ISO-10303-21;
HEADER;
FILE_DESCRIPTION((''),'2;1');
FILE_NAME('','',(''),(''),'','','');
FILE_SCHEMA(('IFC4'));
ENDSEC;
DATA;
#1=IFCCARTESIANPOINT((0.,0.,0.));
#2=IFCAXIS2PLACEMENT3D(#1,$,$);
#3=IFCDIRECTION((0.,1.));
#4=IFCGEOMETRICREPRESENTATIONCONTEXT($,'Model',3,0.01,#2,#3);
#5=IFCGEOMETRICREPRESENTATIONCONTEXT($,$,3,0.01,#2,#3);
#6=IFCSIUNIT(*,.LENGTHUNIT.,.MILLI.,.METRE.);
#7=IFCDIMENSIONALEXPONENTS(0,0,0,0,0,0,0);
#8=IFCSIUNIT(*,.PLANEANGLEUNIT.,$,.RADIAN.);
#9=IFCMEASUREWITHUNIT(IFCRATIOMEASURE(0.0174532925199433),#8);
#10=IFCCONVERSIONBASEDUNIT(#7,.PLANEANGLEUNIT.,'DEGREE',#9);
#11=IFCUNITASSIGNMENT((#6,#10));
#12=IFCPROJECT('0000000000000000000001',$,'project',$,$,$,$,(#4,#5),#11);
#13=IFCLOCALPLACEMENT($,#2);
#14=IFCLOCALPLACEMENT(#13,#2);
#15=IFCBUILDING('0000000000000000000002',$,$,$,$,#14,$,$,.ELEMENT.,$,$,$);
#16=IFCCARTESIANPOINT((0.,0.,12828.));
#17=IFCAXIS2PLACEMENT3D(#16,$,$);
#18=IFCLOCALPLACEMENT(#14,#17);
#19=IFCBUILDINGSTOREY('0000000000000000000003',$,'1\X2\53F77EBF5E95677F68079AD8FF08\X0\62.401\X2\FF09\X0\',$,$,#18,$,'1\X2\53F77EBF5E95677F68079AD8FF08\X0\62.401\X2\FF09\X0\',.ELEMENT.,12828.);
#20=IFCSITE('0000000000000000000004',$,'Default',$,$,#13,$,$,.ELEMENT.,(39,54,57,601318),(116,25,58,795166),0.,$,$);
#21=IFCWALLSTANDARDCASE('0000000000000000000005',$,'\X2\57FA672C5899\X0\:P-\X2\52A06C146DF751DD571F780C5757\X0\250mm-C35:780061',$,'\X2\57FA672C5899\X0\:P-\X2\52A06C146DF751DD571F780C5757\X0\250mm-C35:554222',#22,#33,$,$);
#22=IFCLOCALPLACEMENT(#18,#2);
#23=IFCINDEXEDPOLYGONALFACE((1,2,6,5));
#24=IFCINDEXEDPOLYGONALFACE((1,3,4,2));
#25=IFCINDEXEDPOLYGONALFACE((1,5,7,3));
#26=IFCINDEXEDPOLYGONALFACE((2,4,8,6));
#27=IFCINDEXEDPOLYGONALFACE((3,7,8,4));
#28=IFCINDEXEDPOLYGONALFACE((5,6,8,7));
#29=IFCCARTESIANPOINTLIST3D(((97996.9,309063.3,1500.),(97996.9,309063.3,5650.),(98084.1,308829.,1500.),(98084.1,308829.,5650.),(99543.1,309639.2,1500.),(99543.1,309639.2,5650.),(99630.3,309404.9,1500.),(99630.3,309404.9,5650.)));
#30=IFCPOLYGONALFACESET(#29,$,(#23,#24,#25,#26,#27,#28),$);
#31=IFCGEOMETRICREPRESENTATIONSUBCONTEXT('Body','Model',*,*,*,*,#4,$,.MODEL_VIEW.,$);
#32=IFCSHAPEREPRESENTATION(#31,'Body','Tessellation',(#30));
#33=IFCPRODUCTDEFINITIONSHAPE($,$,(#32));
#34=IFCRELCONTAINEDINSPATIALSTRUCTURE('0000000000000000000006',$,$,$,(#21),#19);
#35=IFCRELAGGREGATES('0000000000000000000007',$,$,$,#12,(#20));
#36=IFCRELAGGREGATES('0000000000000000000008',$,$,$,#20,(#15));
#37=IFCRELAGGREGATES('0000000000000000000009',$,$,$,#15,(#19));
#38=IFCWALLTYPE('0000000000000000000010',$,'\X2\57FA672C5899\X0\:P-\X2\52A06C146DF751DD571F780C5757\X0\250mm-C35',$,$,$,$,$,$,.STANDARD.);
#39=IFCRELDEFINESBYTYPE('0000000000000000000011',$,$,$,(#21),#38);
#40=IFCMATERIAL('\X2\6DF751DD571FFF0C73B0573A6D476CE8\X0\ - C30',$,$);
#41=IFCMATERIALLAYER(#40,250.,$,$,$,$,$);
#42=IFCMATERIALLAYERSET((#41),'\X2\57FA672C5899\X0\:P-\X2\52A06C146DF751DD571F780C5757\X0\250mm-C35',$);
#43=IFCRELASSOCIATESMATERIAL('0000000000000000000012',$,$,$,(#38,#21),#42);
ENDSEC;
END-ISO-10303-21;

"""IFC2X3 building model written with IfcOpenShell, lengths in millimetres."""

from ifc_helpers import new_model, entity, si_unit, converted_unit, direction, frame, frame_2d, origin, place, context, subcontext, project, spatial, polyline, rectangle, extrude, clip, bounded_halfspace, material, layer, layer_set, layer_usage, type_object, element, save


model = new_model("IFC2X3")

# Units and contexts
model_context = context("Model", 3, precision=0.01, world=origin(), true_north=direction((0.0, 1.0)))
context_of_model = context(None, 3, precision=0.01, world=origin(), true_north=direction((0.0, 1.0)))
body_context = subcontext(model_context, "Body", "Model", "MODEL_VIEW")
ifc_project = project(units=[si_unit("LENGTHUNIT", "METRE", prefix="MILLI"), converted_unit("PLANEANGLEUNIT", "DEGREE", entity("IfcRatioMeasure", 0.0174532925199433), si_unit("PLANEANGLEUNIT", "RADIAN"), dimensions=[0, 0, 0, 0, 0, 0, 0])], contexts=[model_context, context_of_model])

# Site, building, storey
site_placement = place(None, origin())
site = spatial("IfcSite", under=ifc_project, at=site_placement, Name="Default", CompositionType="ELEMENT", RefLatitude=(39, 54, 57, 601318), RefLongitude=(116, 25, 58, 795166), RefElevation=0.0)
building_placement = place(site_placement, origin())
building = spatial("IfcBuilding", under=site, at=building_placement, CompositionType="ELEMENT")
storey_placement = place(building_placement, frame((0.0, 0.0, 12828.0)))
storey = spatial("IfcBuildingStorey", under=building, at=storey_placement, Name="1号线底板标高（62.401）", LongName="1号线底板标高（62.401）", CompositionType="ELEMENT", Elevation=12828.0)

# Wall
ifc_material_1 = material(Name="混凝土，现场浇注 - C30")
ifc_layer_1 = layer(ifc_material_1, 250.0)
ifc_layer_set_1 = layer_set([ifc_layer_1], Name="基本墙:P-加气混凝土砌块250mm-C35")
wall_type_1 = type_object("IfcWallType", Name="基本墙:P-加气混凝土砌块250mm-C35", PredefinedType="STANDARD", material=ifc_layer_set_1)
ifc_layer_usage_1 = layer_usage(ifc_layer_set_1, "AXIS2", "NEGATIVE", 125.0)
wall_1_placement = place(storey_placement, frame((99586.7, 309522.1, 1500.0), z_axis=(0.0, 0.0, 1.0), x_axis=(-0.937112, -0.349028, 0.0)))
element("IfcWallStandardCase", 1, at=wall_1_placement, inside=storey, type_object=wall_type_1, material=ifc_layer_usage_1, Name="基本墙:P-加气混凝土砌块250mm-C35:780061", ObjectType="基本墙:P-加气混凝土砌块250mm-C35:554222", context=body_context, shape_type="Clipping", body=[
    clip(extrude(rectangle(XDim=1650.0, YDim=250.0, at=frame_2d((825.0, 0.0), x_axis=(-1.0, 0.0))), origin(), (0.0, 0.0, 1.0), 4150.0), bounded_halfspace(frame((0.0, -125.0, 4150.0), z_axis=(0.0, 0.0, -1.0), x_axis=(-1.0, 0.0, 0.0)), True, frame((0.0, -125.0, 4150.0)), polyline([(0.0, 0.0), (1650.0, 0.0), (1650.0, 250.0), (0.0, 250.0), (0.0, 0.0)]))),
])

save(model, "model.ifc")
